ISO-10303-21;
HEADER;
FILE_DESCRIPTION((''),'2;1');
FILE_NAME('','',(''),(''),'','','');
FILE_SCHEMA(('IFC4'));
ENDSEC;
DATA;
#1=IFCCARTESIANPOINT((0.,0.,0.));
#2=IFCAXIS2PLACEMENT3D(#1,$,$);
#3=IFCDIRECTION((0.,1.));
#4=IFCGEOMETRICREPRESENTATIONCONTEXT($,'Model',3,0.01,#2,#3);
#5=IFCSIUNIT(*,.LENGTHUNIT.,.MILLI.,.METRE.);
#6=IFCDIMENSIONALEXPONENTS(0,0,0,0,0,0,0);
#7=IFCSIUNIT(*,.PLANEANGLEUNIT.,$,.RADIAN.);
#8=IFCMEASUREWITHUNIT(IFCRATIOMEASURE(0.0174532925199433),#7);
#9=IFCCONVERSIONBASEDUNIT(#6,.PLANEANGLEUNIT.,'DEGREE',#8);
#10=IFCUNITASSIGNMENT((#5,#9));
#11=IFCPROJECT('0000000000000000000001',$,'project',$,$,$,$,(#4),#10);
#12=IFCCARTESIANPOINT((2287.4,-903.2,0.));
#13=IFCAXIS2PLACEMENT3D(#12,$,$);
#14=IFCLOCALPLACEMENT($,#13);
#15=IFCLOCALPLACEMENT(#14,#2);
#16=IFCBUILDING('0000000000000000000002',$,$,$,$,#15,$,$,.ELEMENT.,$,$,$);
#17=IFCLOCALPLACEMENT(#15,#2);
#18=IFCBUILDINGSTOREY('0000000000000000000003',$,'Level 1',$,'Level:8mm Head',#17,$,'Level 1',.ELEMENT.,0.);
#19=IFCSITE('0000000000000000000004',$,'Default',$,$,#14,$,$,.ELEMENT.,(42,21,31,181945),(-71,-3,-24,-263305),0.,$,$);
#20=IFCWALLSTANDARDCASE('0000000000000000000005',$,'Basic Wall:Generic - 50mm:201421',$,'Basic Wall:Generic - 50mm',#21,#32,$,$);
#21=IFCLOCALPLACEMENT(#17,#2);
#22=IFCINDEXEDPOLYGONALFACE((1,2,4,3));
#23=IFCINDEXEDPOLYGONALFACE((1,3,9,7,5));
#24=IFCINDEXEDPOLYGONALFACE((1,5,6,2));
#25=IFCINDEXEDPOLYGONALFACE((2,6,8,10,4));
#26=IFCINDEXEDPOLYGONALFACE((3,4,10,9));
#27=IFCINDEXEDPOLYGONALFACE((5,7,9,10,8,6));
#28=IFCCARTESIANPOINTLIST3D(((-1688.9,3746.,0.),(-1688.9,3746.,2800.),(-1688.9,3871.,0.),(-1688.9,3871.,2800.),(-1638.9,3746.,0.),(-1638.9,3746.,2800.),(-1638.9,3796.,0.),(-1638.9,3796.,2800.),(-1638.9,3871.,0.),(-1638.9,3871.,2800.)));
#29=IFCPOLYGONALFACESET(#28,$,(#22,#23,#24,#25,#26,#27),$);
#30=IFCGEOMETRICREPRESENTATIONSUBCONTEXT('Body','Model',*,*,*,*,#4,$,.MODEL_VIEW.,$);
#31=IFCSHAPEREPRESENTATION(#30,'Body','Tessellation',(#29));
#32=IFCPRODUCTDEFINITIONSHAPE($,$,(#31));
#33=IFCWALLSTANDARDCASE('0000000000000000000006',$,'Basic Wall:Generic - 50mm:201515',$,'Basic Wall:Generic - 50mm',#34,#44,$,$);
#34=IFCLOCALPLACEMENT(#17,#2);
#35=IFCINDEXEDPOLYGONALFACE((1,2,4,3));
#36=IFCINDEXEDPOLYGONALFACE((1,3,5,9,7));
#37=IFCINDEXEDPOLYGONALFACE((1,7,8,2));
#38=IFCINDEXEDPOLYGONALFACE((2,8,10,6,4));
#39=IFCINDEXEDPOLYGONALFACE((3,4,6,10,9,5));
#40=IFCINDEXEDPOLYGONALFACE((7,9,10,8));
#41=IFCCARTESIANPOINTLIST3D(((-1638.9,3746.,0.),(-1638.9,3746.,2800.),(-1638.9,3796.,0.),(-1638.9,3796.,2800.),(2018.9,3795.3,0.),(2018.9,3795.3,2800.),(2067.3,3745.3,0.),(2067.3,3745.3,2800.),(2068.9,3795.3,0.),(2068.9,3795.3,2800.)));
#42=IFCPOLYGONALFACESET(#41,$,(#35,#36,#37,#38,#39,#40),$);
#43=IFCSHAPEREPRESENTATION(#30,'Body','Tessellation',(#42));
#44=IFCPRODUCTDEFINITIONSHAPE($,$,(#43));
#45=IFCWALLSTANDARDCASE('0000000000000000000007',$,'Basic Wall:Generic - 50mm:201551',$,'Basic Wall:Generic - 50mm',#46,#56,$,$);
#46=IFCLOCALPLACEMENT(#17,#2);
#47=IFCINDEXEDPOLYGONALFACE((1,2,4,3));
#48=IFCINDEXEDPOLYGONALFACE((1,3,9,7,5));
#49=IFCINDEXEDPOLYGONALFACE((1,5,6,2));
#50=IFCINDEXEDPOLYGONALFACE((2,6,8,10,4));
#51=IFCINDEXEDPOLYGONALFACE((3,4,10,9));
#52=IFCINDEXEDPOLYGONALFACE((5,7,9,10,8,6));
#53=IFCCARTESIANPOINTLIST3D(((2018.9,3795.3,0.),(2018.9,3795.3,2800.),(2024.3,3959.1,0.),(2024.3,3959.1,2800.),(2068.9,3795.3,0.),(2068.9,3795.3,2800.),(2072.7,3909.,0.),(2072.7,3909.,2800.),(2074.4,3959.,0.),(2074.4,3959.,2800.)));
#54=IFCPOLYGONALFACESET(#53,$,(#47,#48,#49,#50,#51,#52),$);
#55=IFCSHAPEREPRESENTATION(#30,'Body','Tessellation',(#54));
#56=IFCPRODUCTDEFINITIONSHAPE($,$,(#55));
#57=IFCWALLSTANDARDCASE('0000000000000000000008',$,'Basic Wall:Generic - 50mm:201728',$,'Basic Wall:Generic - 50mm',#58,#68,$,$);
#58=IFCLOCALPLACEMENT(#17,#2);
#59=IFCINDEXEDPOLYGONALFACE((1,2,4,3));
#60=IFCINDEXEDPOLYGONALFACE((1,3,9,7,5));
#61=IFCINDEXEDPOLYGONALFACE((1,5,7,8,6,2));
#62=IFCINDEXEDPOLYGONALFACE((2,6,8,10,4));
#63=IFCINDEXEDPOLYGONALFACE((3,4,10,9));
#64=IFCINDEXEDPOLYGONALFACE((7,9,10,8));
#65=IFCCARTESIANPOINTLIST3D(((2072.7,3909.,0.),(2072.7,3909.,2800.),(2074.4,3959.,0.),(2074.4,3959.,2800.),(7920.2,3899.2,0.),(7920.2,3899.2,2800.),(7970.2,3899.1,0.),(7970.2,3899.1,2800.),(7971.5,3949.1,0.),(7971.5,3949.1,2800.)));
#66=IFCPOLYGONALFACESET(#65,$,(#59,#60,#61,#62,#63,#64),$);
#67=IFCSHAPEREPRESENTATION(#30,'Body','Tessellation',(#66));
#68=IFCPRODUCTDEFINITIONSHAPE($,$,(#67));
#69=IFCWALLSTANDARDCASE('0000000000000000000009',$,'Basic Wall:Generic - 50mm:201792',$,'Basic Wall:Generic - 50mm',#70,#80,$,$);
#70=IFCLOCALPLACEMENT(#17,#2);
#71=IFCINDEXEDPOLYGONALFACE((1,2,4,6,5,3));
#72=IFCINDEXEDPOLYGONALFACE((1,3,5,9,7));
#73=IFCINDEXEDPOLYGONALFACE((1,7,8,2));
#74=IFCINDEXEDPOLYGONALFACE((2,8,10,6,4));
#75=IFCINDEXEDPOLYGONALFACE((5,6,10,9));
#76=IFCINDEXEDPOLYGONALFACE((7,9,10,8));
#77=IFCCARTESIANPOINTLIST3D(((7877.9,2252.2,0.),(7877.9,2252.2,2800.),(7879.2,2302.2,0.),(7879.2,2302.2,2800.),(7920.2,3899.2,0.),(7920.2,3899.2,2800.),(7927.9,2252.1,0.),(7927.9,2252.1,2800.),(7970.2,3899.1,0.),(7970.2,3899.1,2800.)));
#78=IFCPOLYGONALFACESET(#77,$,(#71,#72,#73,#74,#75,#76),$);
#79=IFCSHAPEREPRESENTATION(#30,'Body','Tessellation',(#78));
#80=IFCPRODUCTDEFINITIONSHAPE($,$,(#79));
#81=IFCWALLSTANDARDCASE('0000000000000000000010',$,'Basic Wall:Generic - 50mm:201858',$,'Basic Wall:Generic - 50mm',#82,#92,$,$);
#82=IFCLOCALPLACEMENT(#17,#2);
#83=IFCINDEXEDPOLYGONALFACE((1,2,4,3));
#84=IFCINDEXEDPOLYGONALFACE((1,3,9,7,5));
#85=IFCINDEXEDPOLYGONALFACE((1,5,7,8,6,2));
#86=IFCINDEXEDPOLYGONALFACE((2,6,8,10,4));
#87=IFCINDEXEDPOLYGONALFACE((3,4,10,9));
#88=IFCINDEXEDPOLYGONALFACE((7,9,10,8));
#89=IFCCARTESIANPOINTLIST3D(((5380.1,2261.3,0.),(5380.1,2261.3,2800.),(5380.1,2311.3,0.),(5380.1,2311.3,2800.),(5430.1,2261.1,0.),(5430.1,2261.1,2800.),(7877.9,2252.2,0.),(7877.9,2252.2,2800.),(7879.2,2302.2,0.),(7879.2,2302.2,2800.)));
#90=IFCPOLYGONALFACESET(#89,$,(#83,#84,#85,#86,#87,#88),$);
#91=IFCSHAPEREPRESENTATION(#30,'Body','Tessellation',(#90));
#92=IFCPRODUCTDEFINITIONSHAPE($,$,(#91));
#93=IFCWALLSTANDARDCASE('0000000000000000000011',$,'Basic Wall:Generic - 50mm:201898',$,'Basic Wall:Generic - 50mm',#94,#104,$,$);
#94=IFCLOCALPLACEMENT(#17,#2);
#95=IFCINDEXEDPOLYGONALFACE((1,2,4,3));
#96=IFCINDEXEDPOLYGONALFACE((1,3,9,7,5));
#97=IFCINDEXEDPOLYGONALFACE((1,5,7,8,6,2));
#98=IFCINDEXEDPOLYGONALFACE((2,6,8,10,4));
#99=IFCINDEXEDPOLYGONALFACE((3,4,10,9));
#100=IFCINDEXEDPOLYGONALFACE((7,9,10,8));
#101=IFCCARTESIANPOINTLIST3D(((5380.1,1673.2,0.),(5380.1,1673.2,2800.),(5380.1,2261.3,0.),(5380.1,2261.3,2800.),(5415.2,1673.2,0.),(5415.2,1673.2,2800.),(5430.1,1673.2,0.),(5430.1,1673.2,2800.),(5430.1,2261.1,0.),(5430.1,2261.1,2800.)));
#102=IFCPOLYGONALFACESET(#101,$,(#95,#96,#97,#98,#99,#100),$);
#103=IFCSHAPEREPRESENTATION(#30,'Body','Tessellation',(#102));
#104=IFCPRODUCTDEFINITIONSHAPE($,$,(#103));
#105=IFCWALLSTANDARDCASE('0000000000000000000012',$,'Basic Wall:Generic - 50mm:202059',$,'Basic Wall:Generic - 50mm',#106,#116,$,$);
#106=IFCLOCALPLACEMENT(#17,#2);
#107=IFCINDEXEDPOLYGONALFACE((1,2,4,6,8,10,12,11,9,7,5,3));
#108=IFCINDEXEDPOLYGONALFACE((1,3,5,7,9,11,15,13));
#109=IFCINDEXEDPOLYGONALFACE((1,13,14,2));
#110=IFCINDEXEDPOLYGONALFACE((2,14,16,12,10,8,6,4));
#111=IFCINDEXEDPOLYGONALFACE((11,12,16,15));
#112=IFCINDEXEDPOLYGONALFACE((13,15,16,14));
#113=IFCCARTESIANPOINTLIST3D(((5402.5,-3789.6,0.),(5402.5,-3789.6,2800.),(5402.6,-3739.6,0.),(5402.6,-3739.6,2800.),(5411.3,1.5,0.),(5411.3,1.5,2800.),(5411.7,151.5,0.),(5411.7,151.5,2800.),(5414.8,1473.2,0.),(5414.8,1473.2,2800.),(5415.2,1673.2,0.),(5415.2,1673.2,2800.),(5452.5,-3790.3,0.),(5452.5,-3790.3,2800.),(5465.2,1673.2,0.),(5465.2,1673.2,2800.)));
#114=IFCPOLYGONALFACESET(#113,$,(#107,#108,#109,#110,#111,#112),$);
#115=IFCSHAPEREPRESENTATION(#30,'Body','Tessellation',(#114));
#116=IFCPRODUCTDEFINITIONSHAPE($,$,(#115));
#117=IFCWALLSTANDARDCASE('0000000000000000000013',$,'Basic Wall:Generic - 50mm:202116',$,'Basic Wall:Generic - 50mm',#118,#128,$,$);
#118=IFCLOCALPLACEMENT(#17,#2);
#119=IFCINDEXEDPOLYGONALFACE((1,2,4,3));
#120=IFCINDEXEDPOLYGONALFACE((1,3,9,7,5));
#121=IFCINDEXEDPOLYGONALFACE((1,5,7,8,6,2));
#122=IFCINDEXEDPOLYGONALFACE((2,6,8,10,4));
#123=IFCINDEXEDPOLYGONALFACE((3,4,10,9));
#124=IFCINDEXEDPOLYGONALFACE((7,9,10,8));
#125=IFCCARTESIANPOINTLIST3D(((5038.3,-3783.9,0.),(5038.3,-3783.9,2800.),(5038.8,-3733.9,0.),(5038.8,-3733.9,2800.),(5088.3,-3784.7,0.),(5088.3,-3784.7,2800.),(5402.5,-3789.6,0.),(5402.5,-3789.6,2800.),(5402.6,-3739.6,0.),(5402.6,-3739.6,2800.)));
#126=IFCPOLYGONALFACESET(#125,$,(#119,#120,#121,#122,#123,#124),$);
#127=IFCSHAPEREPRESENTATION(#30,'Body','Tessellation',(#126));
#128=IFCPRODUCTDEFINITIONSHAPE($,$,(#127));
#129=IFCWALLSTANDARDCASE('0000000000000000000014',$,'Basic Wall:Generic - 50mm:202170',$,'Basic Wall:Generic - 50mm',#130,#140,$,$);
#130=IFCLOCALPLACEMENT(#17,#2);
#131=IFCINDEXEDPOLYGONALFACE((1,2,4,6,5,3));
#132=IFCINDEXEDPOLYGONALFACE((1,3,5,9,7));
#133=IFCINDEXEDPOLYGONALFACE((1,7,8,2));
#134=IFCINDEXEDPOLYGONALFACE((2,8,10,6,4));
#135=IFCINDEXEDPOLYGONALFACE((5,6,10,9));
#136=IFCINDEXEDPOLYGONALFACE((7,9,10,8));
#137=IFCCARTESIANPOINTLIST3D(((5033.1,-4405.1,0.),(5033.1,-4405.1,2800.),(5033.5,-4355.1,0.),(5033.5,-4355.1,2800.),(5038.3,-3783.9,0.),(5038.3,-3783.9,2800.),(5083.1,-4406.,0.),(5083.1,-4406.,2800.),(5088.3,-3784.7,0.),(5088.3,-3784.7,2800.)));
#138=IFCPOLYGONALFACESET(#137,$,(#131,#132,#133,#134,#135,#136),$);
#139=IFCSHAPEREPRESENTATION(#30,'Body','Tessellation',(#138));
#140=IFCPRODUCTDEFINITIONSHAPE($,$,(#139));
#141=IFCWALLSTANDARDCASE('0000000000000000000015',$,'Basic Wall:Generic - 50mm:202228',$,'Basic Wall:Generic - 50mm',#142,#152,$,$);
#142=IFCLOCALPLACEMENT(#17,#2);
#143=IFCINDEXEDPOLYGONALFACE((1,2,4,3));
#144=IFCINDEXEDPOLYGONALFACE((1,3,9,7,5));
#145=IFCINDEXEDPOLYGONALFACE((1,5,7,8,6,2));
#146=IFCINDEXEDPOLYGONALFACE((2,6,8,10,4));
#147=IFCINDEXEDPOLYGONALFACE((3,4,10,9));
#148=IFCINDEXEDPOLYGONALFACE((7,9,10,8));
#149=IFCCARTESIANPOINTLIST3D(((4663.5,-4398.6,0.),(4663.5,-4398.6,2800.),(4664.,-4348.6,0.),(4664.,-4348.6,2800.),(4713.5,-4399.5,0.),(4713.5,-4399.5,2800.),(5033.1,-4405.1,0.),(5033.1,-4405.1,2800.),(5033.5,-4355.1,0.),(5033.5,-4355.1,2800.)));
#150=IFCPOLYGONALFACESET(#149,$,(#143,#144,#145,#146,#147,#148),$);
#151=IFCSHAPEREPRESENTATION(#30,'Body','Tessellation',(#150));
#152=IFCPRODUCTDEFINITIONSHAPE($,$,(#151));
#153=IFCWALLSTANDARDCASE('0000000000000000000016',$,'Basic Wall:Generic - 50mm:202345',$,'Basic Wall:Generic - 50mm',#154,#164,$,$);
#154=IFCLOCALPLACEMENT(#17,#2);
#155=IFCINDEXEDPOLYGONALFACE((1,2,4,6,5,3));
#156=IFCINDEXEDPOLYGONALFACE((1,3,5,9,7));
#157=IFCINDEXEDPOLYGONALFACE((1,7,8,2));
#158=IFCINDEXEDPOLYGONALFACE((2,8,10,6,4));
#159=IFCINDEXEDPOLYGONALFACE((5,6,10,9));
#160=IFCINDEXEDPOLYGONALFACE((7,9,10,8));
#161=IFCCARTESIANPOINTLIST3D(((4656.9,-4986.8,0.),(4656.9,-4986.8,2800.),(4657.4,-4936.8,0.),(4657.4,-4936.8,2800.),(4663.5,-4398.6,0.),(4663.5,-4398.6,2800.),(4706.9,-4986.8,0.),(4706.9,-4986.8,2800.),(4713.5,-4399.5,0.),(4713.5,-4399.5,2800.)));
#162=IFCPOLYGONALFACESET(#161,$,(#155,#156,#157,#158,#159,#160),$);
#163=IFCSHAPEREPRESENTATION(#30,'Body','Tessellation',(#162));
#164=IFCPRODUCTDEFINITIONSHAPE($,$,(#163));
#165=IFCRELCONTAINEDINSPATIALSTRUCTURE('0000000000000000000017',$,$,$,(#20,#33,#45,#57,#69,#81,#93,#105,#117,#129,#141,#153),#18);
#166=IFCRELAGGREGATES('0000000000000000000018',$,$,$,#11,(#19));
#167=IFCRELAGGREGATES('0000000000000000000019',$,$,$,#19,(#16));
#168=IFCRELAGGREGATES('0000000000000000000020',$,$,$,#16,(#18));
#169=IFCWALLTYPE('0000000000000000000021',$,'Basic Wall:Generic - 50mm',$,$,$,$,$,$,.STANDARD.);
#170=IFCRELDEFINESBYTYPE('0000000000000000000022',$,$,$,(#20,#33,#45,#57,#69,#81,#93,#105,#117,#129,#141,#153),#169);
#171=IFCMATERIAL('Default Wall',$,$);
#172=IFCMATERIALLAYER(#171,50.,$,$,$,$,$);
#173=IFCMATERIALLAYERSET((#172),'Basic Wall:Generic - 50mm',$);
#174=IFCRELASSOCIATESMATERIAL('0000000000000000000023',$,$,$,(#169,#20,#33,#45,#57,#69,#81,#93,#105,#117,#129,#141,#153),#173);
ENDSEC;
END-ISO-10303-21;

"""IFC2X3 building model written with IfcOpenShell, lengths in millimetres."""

from ifc_helpers import new_model, entity, si_unit, converted_unit, direction, frame, origin, place, context, subcontext, project, spatial, polyline, outline, extrude, material, layer, layer_set, layer_usage, type_object, element, save


model = new_model("IFC2X3")

# Units and contexts
model_context = context("Model", 3, precision=0.01, world=origin(), true_north=direction((0.0, 1.0)))
body_context = subcontext(model_context, "Body", "Model", "MODEL_VIEW")
ifc_project = project(units=[si_unit("LENGTHUNIT", "METRE", prefix="MILLI"), converted_unit("PLANEANGLEUNIT", "DEGREE", entity("IfcRatioMeasure", 0.0174532925199433), si_unit("PLANEANGLEUNIT", "RADIAN"), dimensions=[0, 0, 0, 0, 0, 0, 0])], contexts=[model_context])

# Site, building, storey
site_placement = place(None, frame((2287.4, -903.2, 0.0)))
site = spatial("IfcSite", under=ifc_project, at=site_placement, Name="Default", CompositionType="ELEMENT", RefLatitude=(42, 21, 31, 181945), RefLongitude=(-71, -3, -24, -263305), RefElevation=0.0)
building_placement = place(site_placement, origin())
building = spatial("IfcBuilding", under=site, at=building_placement, CompositionType="ELEMENT")
storey_placement = place(building_placement, origin())
storey = spatial("IfcBuildingStorey", under=building, at=storey_placement, Name="Level 1", ObjectType="Level:8mm Head", LongName="Level 1", CompositionType="ELEMENT", Elevation=0.0)

# Walls
ifc_material_1 = material(Name="Default Wall")
ifc_layer_1 = layer(ifc_material_1, 50.0)
ifc_layer_set_1 = layer_set([ifc_layer_1], Name="Basic Wall:Generic - 50mm")
ifc_layer_usage_1 = layer_usage(ifc_layer_set_1, "AXIS2", "POSITIVE", -25.0)
wall_type_1 = type_object("IfcWallType", Name="Basic Wall:Generic - 50mm", PredefinedType="STANDARD", material=ifc_layer_set_1)
wall_1_placement = place(storey_placement, frame((-1663.9, 3871.0, 0.0), z_axis=(0.0, 0.0, 1.0), x_axis=(0.0, -1.0, 0.0)))
element("IfcWallStandardCase", 1, at=wall_1_placement, inside=storey, type_object=wall_type_1, material=ifc_layer_usage_1, Name="Basic Wall:Generic - 50mm:201421", ObjectType="Basic Wall:Generic - 50mm", context=body_context, shape_type="SweptSolid", body=[
    extrude(outline(polyline([(125.0, -25.0), (125.0, 25.0), (75.0, 25.0), (0.0, 25.0), (0.0, -25.0), (125.0, -25.0)])), origin(), (0.0, 0.0, 1.0), 2800.0),
])
ifc_layer_usage_2 = layer_usage(ifc_layer_set_1, "AXIS2", "POSITIVE", -25.0)
wall_2_placement = place(storey_placement, frame((-1638.9, 3771.0, 0.0), z_axis=(0.0, 0.0, 1.0), x_axis=(1.0, -0.000203, 0.0)))
element("IfcWallStandardCase", 2, at=wall_2_placement, inside=storey, type_object=wall_type_1, material=ifc_layer_usage_2, Name="Basic Wall:Generic - 50mm:201515", ObjectType="Basic Wall:Generic - 50mm", context=body_context, shape_type="SweptSolid", body=[
    extrude(outline(polyline([(3706.2, -25.0), (3707.9, 25.0), (3657.8, 25.0), (0.0, 25.0), (0.0, -25.0), (3706.2, -25.0)])), origin(), (0.0, 0.0, 1.0), 2800.0),
])
ifc_layer_usage_3 = layer_usage(ifc_layer_set_1, "AXIS2", "POSITIVE", -25.0)
wall_3_placement = place(storey_placement, frame((2043.9, 3794.5, 0.0), z_axis=(0.0, 0.0, 1.0), x_axis=(0.033015, 0.999455, 0.0)))
element("IfcWallStandardCase", 3, at=wall_3_placement, inside=storey, type_object=wall_type_1, material=ifc_layer_usage_3, Name="Basic Wall:Generic - 50mm:201551", ObjectType="Basic Wall:Generic - 50mm", context=body_context, shape_type="SweptSolid", body=[
    extrude(outline(polyline([(165.4, -25.0), (163.9, 25.0), (0.0, 25.0), (1.6, -25.0), (115.4, -25.0), (165.4, -25.0)])), origin(), (0.0, 0.0, 1.0), 2800.0),
])
ifc_layer_usage_4 = layer_usage(ifc_layer_set_1, "AXIS2", "POSITIVE", -25.0)
wall_4_placement = place(storey_placement, frame((2072.7, 3934.0, 0.0), z_axis=(0.0, 0.0, 1.0), x_axis=(0.999999, -0.001671, 0.0)))
element("IfcWallStandardCase", 4, at=wall_4_placement, inside=storey, type_object=wall_type_1, material=ifc_layer_usage_4, Name="Basic Wall:Generic - 50mm:201728", ObjectType="Basic Wall:Generic - 50mm", context=body_context, shape_type="SweptSolid", body=[
    extrude(outline(polyline([(5897.6, -25.0), (5898.8, 25.0), (1.6, 25.0), (0.0, -25.0), (5847.5, -25.0), (5897.6, -25.0)])), origin(), (0.0, 0.0, 1.0), 2800.0),
])
ifc_layer_usage_5 = layer_usage(ifc_layer_set_1, "AXIS2", "POSITIVE", -25.0)
wall_5_placement = place(storey_placement, frame((7945.3, 3899.8, 0.0), z_axis=(0.0, 0.0, 1.0), x_axis=(-0.025684, -0.99967, 0.0)))
element("IfcWallStandardCase", 5, at=wall_5_placement, inside=storey, type_object=wall_type_1, material=ifc_layer_usage_5, Name="Basic Wall:Generic - 50mm:201792", ObjectType="Basic Wall:Generic - 50mm", context=body_context, shape_type="SweptSolid", body=[
    extrude(outline(polyline([(1648.7, -25.0), (1647.6, 25.0), (0.0, 25.0), (1.2, -25.0), (1598.7, -25.0), (1648.7, -25.0)])), origin(), (0.0, 0.0, 1.0), 2800.0),
])
ifc_layer_usage_6 = layer_usage(ifc_layer_set_1, "AXIS2", "POSITIVE", -25.0)
wall_6_placement = place(storey_placement, frame((7879.1, 2277.2, 0.0), z_axis=(0.0, 0.0, 1.0), x_axis=(-0.999993, 0.00363, 0.0)))
element("IfcWallStandardCase", 6, at=wall_6_placement, inside=storey, type_object=wall_type_1, material=ifc_layer_usage_6, Name="Basic Wall:Generic - 50mm:201858", ObjectType="Basic Wall:Generic - 50mm", context=body_context, shape_type="SweptSolid", body=[
    extrude(outline(polyline([(2499.1, -25.0), (2499.0, 25.0), (2449.0, 25.0), (1.1, 25.0), (0.0, -25.0), (2499.1, -25.0)])), origin(), (0.0, 0.0, 1.0), 2800.0),
])
ifc_layer_usage_7 = layer_usage(ifc_layer_set_1, "AXIS2", "POSITIVE", -25.0)
wall_7_placement = place(storey_placement, frame((5405.1, 2261.3, 0.0), z_axis=(0.0, 0.0, 1.0), x_axis=(0.0, -1.0, 0.0)))
element("IfcWallStandardCase", 7, at=wall_7_placement, inside=storey, type_object=wall_type_1, material=ifc_layer_usage_7, Name="Basic Wall:Generic - 50mm:201898", ObjectType="Basic Wall:Generic - 50mm", context=body_context, shape_type="SweptSolid", body=[
    extrude(outline(polyline([(588.1, -25.0), (588.1, 10.2), (588.1, 25.0), (0.2, 25.0), (0.0, -25.0), (588.1, -25.0)])), origin(), (0.0, 0.0, 1.0), 2800.0),
])
ifc_layer_usage_8 = layer_usage(ifc_layer_set_1, "AXIS2", "POSITIVE", -25.0)
wall_8_placement = place(storey_placement, frame((5440.2, 1673.2, 0.0), z_axis=(0.0, 0.0, 1.0), x_axis=(-0.002327, -0.999997, 0.0)))
element("IfcWallStandardCase", 8, at=wall_8_placement, inside=storey, type_object=wall_type_1, material=ifc_layer_usage_8, Name="Basic Wall:Generic - 50mm:202059", ObjectType="Basic Wall:Generic - 50mm", context=body_context, shape_type="SweptSolid", body=[
    extrude(outline(polyline([(5462.9, -25.0), (5463.5, 25.0), (0.0, 25.0), (0.1, -25.0), (200.1, -25.0), (1521.8, -25.0), (1671.8, -25.0), (5412.9, -25.0), (5462.9, -25.0)])), origin(), (0.0, 0.0, 1.0), 2800.0),
])
ifc_layer_usage_9 = layer_usage(ifc_layer_set_1, "AXIS2", "POSITIVE", -25.0)
wall_9_placement = place(storey_placement, frame((5402.9, -3764.6, 0.0), z_axis=(0.0, 0.0, 1.0), x_axis=(-0.999878, 0.015623, 0.0)))
element("IfcWallStandardCase", 9, at=wall_9_placement, inside=storey, type_object=wall_type_1, material=ifc_layer_usage_9, Name="Basic Wall:Generic - 50mm:202116", ObjectType="Basic Wall:Generic - 50mm", context=body_context, shape_type="SweptSolid", body=[
    extrude(outline(polyline([(364.6, -25.0), (364.2, 25.0), (314.2, 25.0), (0.0, 25.0), (0.7, -25.0), (364.6, -25.0)])), origin(), (0.0, 0.0, 1.0), 2800.0),
])
ifc_layer_usage_10 = layer_usage(ifc_layer_set_1, "AXIS2", "POSITIVE", -25.0)
wall_10_placement = place(storey_placement, frame((5063.3, -3784.1, 0.0), z_axis=(0.0, 0.0, 1.0), x_axis=(-0.008487, -0.999964, 0.0)))
element("IfcWallStandardCase", 10, at=wall_10_placement, inside=storey, type_object=wall_type_1, material=ifc_layer_usage_10, Name="Basic Wall:Generic - 50mm:202170", ObjectType="Basic Wall:Generic - 50mm", context=body_context, shape_type="SweptSolid", body=[
    extrude(outline(polyline([(621.2, -25.0), (621.7, 25.0), (0.4, 25.0), (0.0, -25.0), (571.2, -25.0), (621.2, -25.0)])), origin(), (0.0, 0.0, 1.0), 2800.0),
])
ifc_layer_usage_11 = layer_usage(ifc_layer_set_1, "AXIS2", "POSITIVE", -25.0)
wall_11_placement = place(storey_placement, frame((5033.5, -4380.1, 0.0), z_axis=(0.0, 0.0, 1.0), x_axis=(-0.999846, 0.017532, 0.0)))
element("IfcWallStandardCase", 11, at=wall_11_placement, inside=storey, type_object=wall_type_1, material=ifc_layer_usage_11, Name="Basic Wall:Generic - 50mm:202228", ObjectType="Basic Wall:Generic - 50mm", context=body_context, shape_type="SweptSolid", body=[
    extrude(outline(polyline([(370.0, -25.0), (369.7, 25.0), (319.7, 25.0), (0.0, 25.0), (0.5, -25.0), (370.0, -25.0)])), origin(), (0.0, 0.0, 1.0), 2800.0),
])
ifc_layer_usage_12 = layer_usage(ifc_layer_set_1, "AXIS2", "POSITIVE", -25.0)
wall_12_placement = place(storey_placement, frame((4688.5, -4398.9, 0.0), z_axis=(0.0, 0.0, 1.0), x_axis=(-0.011196, -0.999937, 0.0)))
element("IfcWallStandardCase", 12, at=wall_12_placement, inside=storey, type_object=wall_type_1, material=ifc_layer_usage_12, Name="Basic Wall:Generic - 50mm:202345", ObjectType="Basic Wall:Generic - 50mm", context=body_context, shape_type="SweptSolid", body=[
    extrude(outline(polyline([(588.2, -25.0), (587.6, 25.0), (0.3, 25.0), (0.0, -25.0), (538.2, -25.0), (588.2, -25.0)])), origin(), (0.0, 0.0, 1.0), 2800.0),
])

save(model, "model.ifc")
